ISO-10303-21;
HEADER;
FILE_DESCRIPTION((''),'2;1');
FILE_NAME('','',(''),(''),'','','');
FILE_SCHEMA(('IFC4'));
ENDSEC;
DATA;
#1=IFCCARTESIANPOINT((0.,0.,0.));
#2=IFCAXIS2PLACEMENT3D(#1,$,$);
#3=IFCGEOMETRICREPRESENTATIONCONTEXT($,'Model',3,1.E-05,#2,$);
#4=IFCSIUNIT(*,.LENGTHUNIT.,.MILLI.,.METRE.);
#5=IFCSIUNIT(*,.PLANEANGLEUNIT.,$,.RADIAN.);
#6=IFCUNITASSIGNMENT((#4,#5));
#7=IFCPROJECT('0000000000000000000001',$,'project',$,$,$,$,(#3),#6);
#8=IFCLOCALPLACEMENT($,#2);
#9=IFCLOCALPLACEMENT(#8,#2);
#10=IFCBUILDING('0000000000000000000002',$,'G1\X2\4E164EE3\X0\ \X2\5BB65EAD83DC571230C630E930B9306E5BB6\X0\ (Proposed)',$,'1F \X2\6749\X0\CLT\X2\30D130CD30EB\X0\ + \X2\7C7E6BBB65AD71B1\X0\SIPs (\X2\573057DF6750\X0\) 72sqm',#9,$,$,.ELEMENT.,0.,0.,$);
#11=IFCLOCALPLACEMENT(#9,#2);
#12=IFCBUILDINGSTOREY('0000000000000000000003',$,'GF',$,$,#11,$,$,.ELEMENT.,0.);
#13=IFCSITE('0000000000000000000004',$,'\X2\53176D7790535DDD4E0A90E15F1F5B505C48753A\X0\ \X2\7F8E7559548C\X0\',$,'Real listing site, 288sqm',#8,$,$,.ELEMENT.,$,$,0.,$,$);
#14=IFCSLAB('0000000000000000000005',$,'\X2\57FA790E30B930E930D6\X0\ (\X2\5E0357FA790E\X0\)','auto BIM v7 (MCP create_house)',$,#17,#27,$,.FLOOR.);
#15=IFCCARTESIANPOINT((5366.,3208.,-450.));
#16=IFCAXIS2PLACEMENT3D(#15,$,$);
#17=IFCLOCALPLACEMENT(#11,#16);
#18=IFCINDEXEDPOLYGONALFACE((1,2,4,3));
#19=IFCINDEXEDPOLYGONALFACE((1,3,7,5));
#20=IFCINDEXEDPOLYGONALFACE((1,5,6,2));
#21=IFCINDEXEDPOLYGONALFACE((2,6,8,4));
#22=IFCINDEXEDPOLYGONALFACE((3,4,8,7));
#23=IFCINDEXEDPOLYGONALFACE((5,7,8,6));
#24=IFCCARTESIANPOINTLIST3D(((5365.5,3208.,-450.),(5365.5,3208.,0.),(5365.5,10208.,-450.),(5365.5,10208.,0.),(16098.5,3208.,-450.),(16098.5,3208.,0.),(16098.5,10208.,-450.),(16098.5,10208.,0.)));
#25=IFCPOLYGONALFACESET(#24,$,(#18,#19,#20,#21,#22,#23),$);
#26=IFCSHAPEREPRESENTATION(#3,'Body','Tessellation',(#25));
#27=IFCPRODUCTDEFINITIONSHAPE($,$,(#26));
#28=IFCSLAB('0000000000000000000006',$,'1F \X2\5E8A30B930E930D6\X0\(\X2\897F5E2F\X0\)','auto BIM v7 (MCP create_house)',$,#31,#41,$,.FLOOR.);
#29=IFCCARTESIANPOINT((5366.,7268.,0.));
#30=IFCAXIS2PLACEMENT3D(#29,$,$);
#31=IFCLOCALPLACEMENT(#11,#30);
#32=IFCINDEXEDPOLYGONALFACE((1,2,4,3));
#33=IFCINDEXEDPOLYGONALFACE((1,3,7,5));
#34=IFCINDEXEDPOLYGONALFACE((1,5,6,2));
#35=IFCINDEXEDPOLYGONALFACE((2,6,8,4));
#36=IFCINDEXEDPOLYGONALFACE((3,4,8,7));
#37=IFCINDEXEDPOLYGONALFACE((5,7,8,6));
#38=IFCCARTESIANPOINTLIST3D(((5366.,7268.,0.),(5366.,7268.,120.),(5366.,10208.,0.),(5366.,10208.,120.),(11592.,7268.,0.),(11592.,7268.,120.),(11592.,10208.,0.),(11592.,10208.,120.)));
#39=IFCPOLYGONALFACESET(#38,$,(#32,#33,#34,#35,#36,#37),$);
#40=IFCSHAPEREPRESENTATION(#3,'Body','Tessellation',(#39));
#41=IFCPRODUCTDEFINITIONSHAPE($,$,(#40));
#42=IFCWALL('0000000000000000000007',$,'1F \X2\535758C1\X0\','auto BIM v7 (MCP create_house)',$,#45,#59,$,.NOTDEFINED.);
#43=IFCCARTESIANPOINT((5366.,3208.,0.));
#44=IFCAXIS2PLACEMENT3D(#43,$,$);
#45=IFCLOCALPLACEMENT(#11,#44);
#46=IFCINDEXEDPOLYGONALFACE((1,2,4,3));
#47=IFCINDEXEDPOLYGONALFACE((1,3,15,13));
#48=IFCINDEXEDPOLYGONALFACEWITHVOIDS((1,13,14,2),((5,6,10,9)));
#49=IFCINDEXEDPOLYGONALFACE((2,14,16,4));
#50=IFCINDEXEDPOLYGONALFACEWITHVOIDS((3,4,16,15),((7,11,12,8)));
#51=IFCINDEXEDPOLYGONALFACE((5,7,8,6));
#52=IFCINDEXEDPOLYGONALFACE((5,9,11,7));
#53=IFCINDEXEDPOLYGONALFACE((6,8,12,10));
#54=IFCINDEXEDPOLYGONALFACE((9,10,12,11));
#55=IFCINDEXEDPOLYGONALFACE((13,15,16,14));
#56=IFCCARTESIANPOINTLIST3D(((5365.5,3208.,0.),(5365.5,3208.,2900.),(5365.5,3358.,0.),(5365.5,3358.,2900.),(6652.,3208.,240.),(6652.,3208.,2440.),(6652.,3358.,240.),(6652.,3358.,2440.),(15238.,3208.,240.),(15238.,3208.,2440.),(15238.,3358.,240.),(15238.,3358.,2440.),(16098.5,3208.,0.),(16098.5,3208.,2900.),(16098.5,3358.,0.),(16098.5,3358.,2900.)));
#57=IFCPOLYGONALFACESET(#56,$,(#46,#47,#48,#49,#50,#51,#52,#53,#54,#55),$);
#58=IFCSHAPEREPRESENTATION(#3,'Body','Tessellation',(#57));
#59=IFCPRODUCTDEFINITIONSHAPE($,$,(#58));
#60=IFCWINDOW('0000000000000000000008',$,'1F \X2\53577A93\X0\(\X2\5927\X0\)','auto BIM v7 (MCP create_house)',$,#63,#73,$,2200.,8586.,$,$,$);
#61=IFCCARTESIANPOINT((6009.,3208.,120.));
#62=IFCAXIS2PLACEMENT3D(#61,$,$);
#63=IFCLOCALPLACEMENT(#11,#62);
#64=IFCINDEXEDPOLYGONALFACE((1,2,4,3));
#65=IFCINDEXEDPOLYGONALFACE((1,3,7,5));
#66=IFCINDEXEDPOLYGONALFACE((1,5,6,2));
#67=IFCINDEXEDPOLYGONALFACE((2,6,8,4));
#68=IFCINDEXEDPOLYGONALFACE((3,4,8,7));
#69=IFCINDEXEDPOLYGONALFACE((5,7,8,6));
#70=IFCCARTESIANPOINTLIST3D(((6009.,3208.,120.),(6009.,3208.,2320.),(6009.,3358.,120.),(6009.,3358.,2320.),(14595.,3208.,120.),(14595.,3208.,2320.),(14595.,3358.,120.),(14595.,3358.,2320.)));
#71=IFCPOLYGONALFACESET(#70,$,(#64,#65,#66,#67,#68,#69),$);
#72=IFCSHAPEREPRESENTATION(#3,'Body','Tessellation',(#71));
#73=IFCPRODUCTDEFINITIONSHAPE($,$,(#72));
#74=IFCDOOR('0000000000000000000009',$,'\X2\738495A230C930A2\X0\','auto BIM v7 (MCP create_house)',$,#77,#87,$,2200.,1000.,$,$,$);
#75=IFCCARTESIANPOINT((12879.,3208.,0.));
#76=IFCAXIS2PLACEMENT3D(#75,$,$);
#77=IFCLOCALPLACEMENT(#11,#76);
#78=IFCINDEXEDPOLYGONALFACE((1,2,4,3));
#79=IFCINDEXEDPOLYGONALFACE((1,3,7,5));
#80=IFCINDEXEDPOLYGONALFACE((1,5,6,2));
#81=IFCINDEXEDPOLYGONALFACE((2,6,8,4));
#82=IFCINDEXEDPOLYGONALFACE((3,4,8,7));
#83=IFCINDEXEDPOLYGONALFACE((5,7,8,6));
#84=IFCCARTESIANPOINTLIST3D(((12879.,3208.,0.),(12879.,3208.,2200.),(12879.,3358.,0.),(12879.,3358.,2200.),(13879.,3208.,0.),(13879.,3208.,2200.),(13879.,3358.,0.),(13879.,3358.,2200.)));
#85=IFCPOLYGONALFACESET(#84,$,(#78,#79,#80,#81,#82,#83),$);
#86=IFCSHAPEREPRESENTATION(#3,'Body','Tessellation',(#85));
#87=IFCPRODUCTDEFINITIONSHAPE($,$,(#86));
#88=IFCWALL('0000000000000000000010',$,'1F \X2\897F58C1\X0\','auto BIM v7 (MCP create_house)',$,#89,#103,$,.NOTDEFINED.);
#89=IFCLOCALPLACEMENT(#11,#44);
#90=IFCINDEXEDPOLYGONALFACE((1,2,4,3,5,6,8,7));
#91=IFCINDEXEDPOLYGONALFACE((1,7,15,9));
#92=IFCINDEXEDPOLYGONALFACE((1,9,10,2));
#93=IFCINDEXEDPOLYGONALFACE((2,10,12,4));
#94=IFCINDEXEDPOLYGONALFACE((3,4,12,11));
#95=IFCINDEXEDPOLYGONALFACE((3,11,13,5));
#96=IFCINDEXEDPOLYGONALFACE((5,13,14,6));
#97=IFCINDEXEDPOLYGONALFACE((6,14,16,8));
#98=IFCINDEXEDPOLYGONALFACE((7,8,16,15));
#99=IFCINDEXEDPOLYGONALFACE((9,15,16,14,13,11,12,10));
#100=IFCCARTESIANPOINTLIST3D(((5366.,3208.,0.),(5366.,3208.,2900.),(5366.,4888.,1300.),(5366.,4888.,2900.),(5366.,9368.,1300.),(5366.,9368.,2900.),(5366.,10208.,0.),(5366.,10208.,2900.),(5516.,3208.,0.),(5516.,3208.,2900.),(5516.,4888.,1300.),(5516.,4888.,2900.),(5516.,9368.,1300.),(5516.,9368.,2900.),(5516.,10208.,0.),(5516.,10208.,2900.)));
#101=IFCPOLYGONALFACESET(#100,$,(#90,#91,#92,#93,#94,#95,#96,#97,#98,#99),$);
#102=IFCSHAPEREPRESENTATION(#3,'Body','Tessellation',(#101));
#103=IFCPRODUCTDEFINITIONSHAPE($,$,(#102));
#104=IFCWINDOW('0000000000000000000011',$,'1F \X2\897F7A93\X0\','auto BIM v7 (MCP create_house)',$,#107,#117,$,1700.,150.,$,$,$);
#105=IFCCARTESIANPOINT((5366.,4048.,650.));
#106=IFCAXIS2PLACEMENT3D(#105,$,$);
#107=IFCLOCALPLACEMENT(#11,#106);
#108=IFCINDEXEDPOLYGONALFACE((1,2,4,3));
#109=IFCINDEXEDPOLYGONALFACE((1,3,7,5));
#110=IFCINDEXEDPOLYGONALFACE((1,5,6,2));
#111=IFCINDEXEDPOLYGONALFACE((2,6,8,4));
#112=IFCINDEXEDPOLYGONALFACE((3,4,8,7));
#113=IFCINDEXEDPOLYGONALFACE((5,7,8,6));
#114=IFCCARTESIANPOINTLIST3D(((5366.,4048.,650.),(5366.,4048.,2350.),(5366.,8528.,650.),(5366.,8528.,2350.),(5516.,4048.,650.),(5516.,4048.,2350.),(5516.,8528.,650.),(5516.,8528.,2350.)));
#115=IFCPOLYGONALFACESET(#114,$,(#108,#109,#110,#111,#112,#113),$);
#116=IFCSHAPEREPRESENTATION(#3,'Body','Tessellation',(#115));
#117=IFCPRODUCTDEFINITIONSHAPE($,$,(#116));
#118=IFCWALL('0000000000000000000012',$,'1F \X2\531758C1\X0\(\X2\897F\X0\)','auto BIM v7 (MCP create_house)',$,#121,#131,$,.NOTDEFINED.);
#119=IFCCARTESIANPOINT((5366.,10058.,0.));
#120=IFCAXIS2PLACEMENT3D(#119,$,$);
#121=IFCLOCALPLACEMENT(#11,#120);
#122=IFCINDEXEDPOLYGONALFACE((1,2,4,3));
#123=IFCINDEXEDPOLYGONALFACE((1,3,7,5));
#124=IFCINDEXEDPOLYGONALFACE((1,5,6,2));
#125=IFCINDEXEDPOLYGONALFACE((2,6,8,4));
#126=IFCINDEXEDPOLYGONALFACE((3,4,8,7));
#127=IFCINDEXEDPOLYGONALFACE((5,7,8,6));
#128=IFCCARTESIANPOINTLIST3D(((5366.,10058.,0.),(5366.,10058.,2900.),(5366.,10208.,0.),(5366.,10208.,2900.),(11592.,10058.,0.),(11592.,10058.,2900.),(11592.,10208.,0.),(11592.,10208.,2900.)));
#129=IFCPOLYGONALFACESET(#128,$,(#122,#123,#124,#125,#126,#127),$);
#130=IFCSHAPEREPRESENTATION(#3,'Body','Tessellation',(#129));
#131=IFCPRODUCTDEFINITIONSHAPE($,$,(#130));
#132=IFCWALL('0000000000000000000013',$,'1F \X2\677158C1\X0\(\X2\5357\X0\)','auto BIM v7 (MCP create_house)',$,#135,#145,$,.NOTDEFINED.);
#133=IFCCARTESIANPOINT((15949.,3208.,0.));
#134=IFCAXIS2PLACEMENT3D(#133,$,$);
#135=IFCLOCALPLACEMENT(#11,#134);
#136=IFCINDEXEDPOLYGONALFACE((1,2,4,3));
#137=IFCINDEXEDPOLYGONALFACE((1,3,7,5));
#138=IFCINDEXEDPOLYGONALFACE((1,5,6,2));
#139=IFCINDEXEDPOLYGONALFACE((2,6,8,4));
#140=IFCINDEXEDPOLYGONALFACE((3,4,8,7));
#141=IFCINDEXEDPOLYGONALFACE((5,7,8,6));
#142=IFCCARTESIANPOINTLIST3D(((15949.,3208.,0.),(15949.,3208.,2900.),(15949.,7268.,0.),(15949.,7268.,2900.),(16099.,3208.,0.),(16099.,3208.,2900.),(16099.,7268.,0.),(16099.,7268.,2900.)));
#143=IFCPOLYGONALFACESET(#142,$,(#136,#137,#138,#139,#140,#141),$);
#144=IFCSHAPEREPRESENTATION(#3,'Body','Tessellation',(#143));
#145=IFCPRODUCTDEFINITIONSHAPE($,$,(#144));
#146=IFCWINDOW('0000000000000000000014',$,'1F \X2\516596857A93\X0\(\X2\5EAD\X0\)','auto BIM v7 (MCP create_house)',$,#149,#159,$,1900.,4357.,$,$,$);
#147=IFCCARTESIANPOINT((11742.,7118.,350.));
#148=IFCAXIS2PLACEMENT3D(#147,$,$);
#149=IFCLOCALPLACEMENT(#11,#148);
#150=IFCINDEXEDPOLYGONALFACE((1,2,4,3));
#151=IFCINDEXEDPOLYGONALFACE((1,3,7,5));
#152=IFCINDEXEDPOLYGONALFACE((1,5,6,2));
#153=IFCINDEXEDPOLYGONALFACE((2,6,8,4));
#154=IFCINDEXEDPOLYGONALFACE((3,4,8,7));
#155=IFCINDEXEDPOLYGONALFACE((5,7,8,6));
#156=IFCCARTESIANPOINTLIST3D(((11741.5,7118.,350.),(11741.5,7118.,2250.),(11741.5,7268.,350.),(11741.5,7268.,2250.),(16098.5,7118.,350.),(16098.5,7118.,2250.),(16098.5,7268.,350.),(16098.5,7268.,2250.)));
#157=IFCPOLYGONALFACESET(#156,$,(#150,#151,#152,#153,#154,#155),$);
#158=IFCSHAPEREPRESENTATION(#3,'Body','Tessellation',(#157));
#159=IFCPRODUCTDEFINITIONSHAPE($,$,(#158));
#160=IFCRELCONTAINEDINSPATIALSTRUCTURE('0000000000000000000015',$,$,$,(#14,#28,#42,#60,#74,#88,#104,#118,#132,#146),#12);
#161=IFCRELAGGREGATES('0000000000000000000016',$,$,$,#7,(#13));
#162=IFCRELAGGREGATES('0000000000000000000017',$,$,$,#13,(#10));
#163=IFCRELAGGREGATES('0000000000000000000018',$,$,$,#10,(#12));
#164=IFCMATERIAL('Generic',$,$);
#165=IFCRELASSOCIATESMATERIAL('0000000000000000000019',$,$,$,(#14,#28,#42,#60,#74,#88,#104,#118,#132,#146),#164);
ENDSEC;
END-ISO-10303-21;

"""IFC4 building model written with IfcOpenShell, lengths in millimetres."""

from ifc_helpers import new_model, si_unit, frame, frame_2d, origin, place, context, project, spatial, rectangle, extrude, material, element, fill, save


model = new_model("IFC4")

# Units and contexts
model_context = context("Model", 3, precision=1e-05, world=origin())
ifc_project = project(units=[si_unit("LENGTHUNIT", "METRE", prefix="MILLI"), si_unit("PLANEANGLEUNIT", "RADIAN")], contexts=[model_context])

# Site, building, storey
site_placement = place(None, origin())
site = spatial("IfcSite", under=ifc_project, at=site_placement, Name="北海道川上郡弟子屈町 美留和", ObjectType="Real listing site, 288sqm", CompositionType="ELEMENT", RefElevation=0.0)
building_placement = place(site_placement, origin())
building = spatial("IfcBuilding", under=site, at=building_placement, Name="G1世代 家庭菜園テラスの家 (Proposed)", ObjectType="1F 杉CLTパネル + 籾殻断熱SIPs (地域材) 72sqm", CompositionType="ELEMENT", ElevationOfRefHeight=0.0, ElevationOfTerrain=0.0)
storey_placement = place(building_placement, origin())
storey = spatial("IfcBuildingStorey", under=building, at=storey_placement, Name="GF", CompositionType="ELEMENT", Elevation=0.0)

# Slabs
ifc_material = material(Name="Generic")
slab_1_placement = place(storey_placement, frame((5366.0, 3208.0, -450.0)))
element("IfcSlab", 1, at=slab_1_placement, inside=storey, material=ifc_material, Name="基礎スラブ (布基礎)", Description="auto BIM v7 (MCP create_house)", PredefinedType="FLOOR", context=model_context, shape_type="SweptSolid", body=[
    extrude(rectangle(XDim=10733.0, YDim=7000.0, at=frame_2d((5366.0, 3500.0))), frame((5366.0, 3208.0, -450.0)), (0.0, 0.0, 1.0), 450.0),
])
slab_2_placement = place(storey_placement, frame((5366.0, 7268.0, 0.0)))
element("IfcSlab", 2, at=slab_2_placement, inside=storey, material=ifc_material, Name="1F 床スラブ(西帯)", Description="auto BIM v7 (MCP create_house)", PredefinedType="FLOOR", context=model_context, shape_type="SweptSolid", body=[
    extrude(rectangle(XDim=6226.0, YDim=2940.0, at=frame_2d((3113.0, 1470.0))), frame((5366.0, 7268.0, 0.0)), (0.0, 0.0, 1.0), 120.0),
])

# Wall, openings, window, door
wall_1_placement = place(storey_placement, frame((5366.0, 3208.0, 0.0)))
wall_1 = element("IfcWall", 3, at=wall_1_placement, inside=storey, material=ifc_material, Name="1F 南壁", Description="auto BIM v7 (MCP create_house)", PredefinedType="NOTDEFINED", context=model_context, shape_type="SweptSolid", body=[
    extrude(rectangle(XDim=10733.0, YDim=150.0, at=frame_2d((5366.0, 75.0))), frame((5366.0, 3208.0, 0.0)), (0.0, 0.0, 1.0), 2900.0),
])
opening_1_placement = place(storey_placement, frame((6009.0, 3208.0, 120.0)))
opening_1 = element("IfcOpeningElement", 4, at=opening_1_placement, cuts=wall_1, PredefinedType="NOTDEFINED", context=model_context, shape_type="SweptSolid", body=[
    extrude(rectangle(XDim=8586.0, YDim=150.0, at=frame_2d((4293.0, 75.0))), frame((6009.0, 3208.0, 120.0)), (0.0, 0.0, 1.0), 2200.0),
])
opening_2_placement = place(storey_placement, frame((12879.0, 3208.0, 0.0)))
opening_2 = element("IfcOpeningElement", 5, at=opening_2_placement, cuts=wall_1, PredefinedType="NOTDEFINED", context=model_context, shape_type="SweptSolid", body=[
    extrude(rectangle(XDim=1000.0, YDim=150.0, at=frame_2d((500.0, 75.0))), frame((12879.0, 3208.0, 0.0)), (0.0, 0.0, 1.0), 2200.0),
])
window_1_placement = place(storey_placement, frame((6009.0, 3208.0, 120.0)))
window_1 = element("IfcWindow", 6, at=window_1_placement, inside=storey, material=ifc_material, Name="1F 南窓(大)", Description="auto BIM v7 (MCP create_house)", OverallHeight=2200.0, OverallWidth=8586.0, context=model_context, shape_type="SweptSolid", body=[
    extrude(rectangle(XDim=8586.0, YDim=150.0, at=frame_2d((4293.0, 75.0))), frame((6009.0, 3208.0, 120.0)), (0.0, 0.0, 1.0), 2200.0),
])
fill(opening_1, window_1)
door_placement = place(storey_placement, frame((12879.0, 3208.0, 0.0)))
door = element("IfcDoor", 7, at=door_placement, inside=storey, material=ifc_material, Name="玄関ドア", Description="auto BIM v7 (MCP create_house)", OverallHeight=2200.0, OverallWidth=1000.0, context=model_context, shape_type="SweptSolid", body=[
    extrude(rectangle(XDim=1000.0, YDim=150.0, at=frame_2d((500.0, 75.0))), frame((12879.0, 3208.0, 0.0)), (0.0, 0.0, 1.0), 2200.0),
])
fill(opening_2, door)

# Wall, opening, window
wall_2_placement = place(storey_placement, frame((5366.0, 3208.0, 0.0)))
wall_2 = element("IfcWall", 8, at=wall_2_placement, inside=storey, material=ifc_material, Name="1F 西壁", Description="auto BIM v7 (MCP create_house)", PredefinedType="NOTDEFINED", context=model_context, shape_type="SweptSolid", body=[
    extrude(rectangle(XDim=150.0, YDim=7000.0, at=frame_2d((75.0, 3500.0))), frame((5366.0, 3208.0, 0.0)), (0.0, 0.0, 1.0), 2900.0),
])
opening_3_placement = place(storey_placement, frame((5366.0, 4048.0, 650.0)))
opening_3 = element("IfcOpeningElement", 9, at=opening_3_placement, cuts=wall_2, PredefinedType="NOTDEFINED", context=model_context, shape_type="SweptSolid", body=[
    extrude(rectangle(XDim=150.0, YDim=4480.0, at=frame_2d((75.0, 2240.0))), frame((5366.0, 4048.0, 650.0)), (0.0, 0.0, 1.0), 1700.0),
])
window_2_placement = place(storey_placement, frame((5366.0, 4048.0, 650.0)))
window_2 = element("IfcWindow", 10, at=window_2_placement, inside=storey, material=ifc_material, Name="1F 西窓", Description="auto BIM v7 (MCP create_house)", OverallHeight=1700.0, OverallWidth=150.0, context=model_context, shape_type="SweptSolid", body=[
    extrude(rectangle(XDim=150.0, YDim=4480.0, at=frame_2d((75.0, 2240.0))), frame((5366.0, 4048.0, 650.0)), (0.0, 0.0, 1.0), 1700.0),
])
fill(opening_3, window_2)

# Wall
wall_3_placement = place(storey_placement, frame((5366.0, 10058.0, 0.0)))
element("IfcWall", 11, at=wall_3_placement, inside=storey, material=ifc_material, Name="1F 北壁(西)", Description="auto BIM v7 (MCP create_house)", PredefinedType="NOTDEFINED", context=model_context, shape_type="SweptSolid", body=[
    extrude(rectangle(XDim=6226.0, YDim=150.0, at=frame_2d((3113.0, 75.0))), frame((5366.0, 10058.0, 0.0)), (0.0, 0.0, 1.0), 2900.0),
])

# Wall, opening, window
wall_4_placement = place(storey_placement, frame((15949.0, 3208.0, 0.0)))
wall_4 = element("IfcWall", 12, at=wall_4_placement, inside=storey, material=ifc_material, Name="1F 東壁(南)", Description="auto BIM v7 (MCP create_house)", PredefinedType="NOTDEFINED", context=model_context, shape_type="SweptSolid", body=[
    extrude(rectangle(XDim=150.0, YDim=4060.0, at=frame_2d((75.0, 2030.0))), frame((15949.0, 3208.0, 0.0)), (0.0, 0.0, 1.0), 2900.0),
])
opening_4_placement = place(storey_placement, frame((11742.0, 7118.0, 350.0)))
opening_4 = element("IfcOpeningElement", 13, at=opening_4_placement, cuts=wall_4, PredefinedType="NOTDEFINED", context=model_context, shape_type="SweptSolid", body=[
    extrude(rectangle(XDim=4357.0, YDim=150.0, at=frame_2d((2178.0, 75.0))), frame((11742.0, 7118.0, 350.0)), (0.0, 0.0, 1.0), 1900.0),
])
window_3_placement = place(storey_placement, frame((11742.0, 7118.0, 350.0)))
window_3 = element("IfcWindow", 14, at=window_3_placement, inside=storey, material=ifc_material, Name="1F 入隅窓(庭)", Description="auto BIM v7 (MCP create_house)", OverallHeight=1900.0, OverallWidth=4357.0, context=model_context, shape_type="SweptSolid", body=[
    extrude(rectangle(XDim=4357.0, YDim=150.0, at=frame_2d((2178.0, 75.0))), frame((11742.0, 7118.0, 350.0)), (0.0, 0.0, 1.0), 1900.0),
])
fill(opening_4, window_3)

save(model, "model.ifc")
